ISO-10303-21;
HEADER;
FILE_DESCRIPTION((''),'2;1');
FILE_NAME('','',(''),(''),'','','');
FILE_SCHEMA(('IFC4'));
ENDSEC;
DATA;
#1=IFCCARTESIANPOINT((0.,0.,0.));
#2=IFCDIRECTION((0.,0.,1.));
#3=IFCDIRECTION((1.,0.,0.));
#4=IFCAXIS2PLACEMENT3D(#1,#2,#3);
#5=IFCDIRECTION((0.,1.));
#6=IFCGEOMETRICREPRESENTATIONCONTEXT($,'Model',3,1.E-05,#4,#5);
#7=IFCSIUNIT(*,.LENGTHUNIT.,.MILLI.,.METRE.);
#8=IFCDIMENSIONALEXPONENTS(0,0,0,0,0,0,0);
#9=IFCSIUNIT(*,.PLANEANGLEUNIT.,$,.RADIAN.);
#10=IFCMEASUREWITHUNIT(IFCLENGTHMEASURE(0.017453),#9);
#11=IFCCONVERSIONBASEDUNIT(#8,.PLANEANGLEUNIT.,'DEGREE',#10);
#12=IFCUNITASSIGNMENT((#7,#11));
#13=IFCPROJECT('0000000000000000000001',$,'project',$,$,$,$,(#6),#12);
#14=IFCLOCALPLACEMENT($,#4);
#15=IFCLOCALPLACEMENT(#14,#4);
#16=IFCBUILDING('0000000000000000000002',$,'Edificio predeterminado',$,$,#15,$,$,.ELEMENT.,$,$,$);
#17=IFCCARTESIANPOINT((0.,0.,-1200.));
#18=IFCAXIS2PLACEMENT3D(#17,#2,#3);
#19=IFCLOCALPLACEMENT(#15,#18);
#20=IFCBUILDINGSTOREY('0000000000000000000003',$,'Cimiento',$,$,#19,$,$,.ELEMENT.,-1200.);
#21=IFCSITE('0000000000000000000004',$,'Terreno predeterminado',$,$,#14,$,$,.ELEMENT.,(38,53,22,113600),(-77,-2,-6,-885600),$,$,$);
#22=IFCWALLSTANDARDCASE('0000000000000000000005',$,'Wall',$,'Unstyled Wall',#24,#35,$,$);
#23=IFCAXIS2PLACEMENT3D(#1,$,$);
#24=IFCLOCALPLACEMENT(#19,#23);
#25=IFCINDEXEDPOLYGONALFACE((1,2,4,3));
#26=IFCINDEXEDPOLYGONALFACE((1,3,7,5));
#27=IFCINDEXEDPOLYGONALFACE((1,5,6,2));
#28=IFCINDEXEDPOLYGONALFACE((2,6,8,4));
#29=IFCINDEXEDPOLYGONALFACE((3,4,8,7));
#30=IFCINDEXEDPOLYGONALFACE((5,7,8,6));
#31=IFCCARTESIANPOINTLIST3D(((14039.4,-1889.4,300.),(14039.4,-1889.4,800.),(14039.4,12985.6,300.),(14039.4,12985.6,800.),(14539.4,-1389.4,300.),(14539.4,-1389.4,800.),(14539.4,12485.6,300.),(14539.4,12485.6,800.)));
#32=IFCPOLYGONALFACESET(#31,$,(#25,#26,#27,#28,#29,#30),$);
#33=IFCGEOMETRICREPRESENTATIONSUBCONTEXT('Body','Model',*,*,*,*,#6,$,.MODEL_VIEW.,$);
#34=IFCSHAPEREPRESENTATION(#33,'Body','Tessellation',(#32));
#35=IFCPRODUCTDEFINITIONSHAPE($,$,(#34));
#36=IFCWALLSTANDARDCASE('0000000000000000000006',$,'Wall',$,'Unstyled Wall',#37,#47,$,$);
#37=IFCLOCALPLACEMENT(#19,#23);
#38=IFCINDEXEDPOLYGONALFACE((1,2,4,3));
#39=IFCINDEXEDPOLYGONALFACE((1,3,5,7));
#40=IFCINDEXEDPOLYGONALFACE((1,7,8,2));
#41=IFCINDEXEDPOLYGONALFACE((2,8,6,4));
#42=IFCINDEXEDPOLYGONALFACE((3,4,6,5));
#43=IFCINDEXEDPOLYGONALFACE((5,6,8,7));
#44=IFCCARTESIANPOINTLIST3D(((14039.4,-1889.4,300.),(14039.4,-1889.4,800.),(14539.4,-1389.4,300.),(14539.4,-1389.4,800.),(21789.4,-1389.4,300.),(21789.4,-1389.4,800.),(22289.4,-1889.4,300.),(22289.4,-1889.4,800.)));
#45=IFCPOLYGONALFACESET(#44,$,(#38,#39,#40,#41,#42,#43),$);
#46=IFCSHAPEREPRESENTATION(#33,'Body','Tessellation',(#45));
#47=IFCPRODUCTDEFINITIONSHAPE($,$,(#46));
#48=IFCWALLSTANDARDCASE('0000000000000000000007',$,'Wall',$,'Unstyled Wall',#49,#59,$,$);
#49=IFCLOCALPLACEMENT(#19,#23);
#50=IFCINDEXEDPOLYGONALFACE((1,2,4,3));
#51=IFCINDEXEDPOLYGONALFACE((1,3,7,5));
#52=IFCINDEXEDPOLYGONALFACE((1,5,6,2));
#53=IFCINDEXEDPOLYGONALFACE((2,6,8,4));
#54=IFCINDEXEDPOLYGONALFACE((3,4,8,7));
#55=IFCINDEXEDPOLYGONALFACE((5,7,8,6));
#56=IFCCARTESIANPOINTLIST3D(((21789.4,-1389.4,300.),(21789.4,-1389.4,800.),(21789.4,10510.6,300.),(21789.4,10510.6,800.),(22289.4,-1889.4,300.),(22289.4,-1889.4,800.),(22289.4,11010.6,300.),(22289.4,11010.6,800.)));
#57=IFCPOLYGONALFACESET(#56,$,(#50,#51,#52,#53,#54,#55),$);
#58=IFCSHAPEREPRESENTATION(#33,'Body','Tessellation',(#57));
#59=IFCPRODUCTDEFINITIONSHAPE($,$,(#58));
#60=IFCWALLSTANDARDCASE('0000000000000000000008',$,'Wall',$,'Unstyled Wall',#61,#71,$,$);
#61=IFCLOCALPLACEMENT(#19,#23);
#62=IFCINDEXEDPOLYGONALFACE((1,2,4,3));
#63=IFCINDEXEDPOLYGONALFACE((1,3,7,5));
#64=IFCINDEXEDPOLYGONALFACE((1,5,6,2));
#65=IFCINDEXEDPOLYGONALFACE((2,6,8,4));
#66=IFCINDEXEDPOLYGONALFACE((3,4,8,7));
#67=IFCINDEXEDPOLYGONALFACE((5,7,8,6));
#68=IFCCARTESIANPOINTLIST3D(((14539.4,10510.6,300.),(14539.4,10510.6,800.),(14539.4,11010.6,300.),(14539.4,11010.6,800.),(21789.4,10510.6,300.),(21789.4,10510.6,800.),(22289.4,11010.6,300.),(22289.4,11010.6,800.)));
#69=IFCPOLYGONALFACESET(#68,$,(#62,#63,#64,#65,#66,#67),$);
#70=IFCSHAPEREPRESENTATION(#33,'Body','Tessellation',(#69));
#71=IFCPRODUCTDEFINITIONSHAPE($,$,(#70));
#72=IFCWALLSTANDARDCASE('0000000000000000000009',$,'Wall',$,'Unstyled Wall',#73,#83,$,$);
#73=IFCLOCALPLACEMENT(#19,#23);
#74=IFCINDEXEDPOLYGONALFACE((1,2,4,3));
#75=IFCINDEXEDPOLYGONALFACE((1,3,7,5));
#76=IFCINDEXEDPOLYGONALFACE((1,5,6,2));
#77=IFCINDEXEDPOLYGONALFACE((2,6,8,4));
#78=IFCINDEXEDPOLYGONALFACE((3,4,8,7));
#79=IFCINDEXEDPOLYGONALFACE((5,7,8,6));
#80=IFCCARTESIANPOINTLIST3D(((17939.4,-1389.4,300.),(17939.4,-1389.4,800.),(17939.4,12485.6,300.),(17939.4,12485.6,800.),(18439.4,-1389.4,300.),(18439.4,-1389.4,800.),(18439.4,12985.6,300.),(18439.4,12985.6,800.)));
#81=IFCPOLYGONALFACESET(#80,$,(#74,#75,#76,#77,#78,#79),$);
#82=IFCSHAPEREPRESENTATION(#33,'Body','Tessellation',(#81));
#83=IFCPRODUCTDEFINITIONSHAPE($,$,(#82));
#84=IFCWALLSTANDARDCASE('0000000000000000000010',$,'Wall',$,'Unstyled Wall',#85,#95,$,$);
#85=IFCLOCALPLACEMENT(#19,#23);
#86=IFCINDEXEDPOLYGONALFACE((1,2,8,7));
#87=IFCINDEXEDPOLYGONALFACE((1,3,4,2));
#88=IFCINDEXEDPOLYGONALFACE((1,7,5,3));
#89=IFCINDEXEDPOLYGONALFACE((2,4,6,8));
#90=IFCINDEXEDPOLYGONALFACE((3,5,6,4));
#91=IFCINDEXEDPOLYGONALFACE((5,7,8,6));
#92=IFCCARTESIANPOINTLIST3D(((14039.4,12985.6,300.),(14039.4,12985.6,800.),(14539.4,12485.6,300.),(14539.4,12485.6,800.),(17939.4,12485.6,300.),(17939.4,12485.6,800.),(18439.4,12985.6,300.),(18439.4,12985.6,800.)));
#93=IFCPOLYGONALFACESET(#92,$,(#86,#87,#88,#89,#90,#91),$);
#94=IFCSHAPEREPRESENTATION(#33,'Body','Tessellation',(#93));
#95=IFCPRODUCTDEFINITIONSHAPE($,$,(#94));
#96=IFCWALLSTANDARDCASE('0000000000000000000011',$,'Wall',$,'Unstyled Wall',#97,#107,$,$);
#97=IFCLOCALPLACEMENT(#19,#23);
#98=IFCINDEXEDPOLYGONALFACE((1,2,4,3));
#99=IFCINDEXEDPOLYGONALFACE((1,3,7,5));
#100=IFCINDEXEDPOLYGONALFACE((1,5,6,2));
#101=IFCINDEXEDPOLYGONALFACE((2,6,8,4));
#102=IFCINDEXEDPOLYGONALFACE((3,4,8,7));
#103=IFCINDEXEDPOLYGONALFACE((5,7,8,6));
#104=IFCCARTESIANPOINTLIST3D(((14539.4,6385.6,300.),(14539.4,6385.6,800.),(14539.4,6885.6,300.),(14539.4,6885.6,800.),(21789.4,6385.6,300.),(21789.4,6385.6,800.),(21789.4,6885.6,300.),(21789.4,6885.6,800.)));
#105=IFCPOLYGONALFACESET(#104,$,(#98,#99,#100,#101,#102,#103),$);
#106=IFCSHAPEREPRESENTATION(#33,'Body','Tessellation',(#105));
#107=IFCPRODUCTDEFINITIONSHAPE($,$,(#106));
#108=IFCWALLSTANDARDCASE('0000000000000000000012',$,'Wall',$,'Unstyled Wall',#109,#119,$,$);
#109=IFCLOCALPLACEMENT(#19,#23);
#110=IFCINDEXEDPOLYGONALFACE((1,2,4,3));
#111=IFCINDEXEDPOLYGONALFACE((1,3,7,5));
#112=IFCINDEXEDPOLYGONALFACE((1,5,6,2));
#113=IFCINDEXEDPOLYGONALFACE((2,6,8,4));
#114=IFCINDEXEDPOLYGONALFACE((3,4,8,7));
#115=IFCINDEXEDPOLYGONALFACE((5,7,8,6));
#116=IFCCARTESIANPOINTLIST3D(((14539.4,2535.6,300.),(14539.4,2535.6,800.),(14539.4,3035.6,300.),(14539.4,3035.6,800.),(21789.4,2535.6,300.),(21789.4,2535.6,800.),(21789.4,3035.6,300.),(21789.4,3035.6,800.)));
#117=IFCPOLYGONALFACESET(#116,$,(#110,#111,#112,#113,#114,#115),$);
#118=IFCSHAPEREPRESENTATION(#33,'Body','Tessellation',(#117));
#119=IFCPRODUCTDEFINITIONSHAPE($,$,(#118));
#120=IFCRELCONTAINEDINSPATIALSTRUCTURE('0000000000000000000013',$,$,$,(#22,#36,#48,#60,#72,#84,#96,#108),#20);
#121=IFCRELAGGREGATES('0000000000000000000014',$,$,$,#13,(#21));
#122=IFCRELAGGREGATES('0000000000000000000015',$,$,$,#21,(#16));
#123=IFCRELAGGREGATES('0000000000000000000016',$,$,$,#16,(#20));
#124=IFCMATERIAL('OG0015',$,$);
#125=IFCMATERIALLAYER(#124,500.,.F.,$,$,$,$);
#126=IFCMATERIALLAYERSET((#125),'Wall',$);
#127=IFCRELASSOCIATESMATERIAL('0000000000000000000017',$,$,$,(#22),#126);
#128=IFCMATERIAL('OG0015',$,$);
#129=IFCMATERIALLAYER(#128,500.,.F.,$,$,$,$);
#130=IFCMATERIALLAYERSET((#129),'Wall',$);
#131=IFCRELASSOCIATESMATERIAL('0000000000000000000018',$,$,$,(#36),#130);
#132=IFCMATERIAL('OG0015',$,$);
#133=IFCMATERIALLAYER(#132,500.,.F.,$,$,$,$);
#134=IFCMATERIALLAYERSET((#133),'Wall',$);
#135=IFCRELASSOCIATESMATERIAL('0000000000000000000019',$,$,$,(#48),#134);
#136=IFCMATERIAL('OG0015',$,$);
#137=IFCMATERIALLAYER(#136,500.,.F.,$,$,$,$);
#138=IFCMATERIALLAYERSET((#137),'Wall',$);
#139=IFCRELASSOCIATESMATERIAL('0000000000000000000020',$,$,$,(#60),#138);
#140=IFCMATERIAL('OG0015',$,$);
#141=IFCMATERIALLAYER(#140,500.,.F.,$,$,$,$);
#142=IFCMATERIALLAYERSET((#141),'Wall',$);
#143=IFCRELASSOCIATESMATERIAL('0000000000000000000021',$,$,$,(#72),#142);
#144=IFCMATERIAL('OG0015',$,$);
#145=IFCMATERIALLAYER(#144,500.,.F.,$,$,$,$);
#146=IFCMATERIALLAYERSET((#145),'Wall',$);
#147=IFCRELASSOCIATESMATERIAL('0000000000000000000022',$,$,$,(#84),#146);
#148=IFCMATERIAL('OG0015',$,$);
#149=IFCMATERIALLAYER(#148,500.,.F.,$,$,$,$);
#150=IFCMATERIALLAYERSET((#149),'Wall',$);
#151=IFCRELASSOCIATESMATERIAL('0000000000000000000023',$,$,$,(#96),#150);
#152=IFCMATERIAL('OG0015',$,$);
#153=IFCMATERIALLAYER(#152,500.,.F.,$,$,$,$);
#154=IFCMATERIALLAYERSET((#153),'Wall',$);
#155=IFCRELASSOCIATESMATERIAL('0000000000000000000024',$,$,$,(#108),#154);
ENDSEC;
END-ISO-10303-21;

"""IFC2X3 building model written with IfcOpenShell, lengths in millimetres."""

from ifc_helpers import new_model, entity, si_unit, converted_unit, direction, frame, origin_with_axes, place, context, subcontext, project, spatial, polyline, outline, extrude, material, layer, layer_set, layer_usage, element, save


model = new_model("IFC2X3")

# Units and contexts
model_context = context("Model", 3, precision=1e-05, world=origin_with_axes(), true_north=direction((0.0, 1.0)))
body_context = subcontext(model_context, "Body", "Model", "MODEL_VIEW")
ifc_project = project(units=[si_unit("LENGTHUNIT", "METRE", prefix="MILLI"), converted_unit("PLANEANGLEUNIT", "DEGREE", entity("IfcLengthMeasure", 0.017453), si_unit("PLANEANGLEUNIT", "RADIAN"), dimensions=[0, 0, 0, 0, 0, 0, 0])], contexts=[model_context])

# Site, building, storey
site_placement = place(None, origin_with_axes())
site = spatial("IfcSite", under=ifc_project, at=site_placement, Name="Terreno predeterminado", CompositionType="ELEMENT", RefLatitude=(38, 53, 22, 113600), RefLongitude=(-77, -2, -6, -885600))
building_placement = place(site_placement, origin_with_axes())
building = spatial("IfcBuilding", under=site, at=building_placement, Name="Edificio predeterminado", CompositionType="ELEMENT")
storey_placement = place(building_placement, frame((0.0, 0.0, -1200.0), z_axis=(0.0, 0.0, 1.0), x_axis=(1.0, 0.0, 0.0)))
storey = spatial("IfcBuildingStorey", under=building, at=storey_placement, Name="Cimiento", CompositionType="ELEMENT", Elevation=-1200.0)

# Walls
ifc_material_1 = material(Name="OG0015")
ifc_layer_1 = layer(ifc_material_1, 500.0, ventilated=False)
ifc_layer_set_1 = layer_set([ifc_layer_1], Name="Wall")
ifc_layer_usage_1 = layer_usage(ifc_layer_set_1, "AXIS2", "POSITIVE", -250.0)
wall_1_placement = place(storey_placement, frame((14289.4, 12735.6, 300.0), z_axis=(0.0, 0.0, 1.0), x_axis=(0.0, -1.0, 0.0)))
element("IfcWallStandardCase", 1, at=wall_1_placement, inside=storey, material=ifc_layer_usage_1, Name="Wall", ObjectType="Unstyled Wall", context=body_context, shape_type="SweptSolid", body=[
    extrude(outline(polyline([(250.0, 250.0), (-250.0, -250.0), (14625.0, -250.0), (14125.0, 250.0), (250.0, 250.0)])), origin_with_axes(), (0.0, 0.0, 1.0), 500.0),
])
ifc_material_2 = material(Name="OG0015")
ifc_layer_2 = layer(ifc_material_2, 500.0, ventilated=False)
ifc_layer_set_2 = layer_set([ifc_layer_2], Name="Wall")
ifc_layer_usage_2 = layer_usage(ifc_layer_set_2, "AXIS2", "POSITIVE", -250.0)
wall_2_placement = place(storey_placement, frame((14289.4, -1639.4, 300.0), z_axis=(0.0, 0.0, 1.0), x_axis=(1.0, 0.0, 0.0)))
element("IfcWallStandardCase", 2, at=wall_2_placement, inside=storey, material=ifc_layer_usage_2, Name="Wall", ObjectType="Unstyled Wall", context=body_context, shape_type="SweptSolid", body=[
    extrude(outline(polyline([(-250.0, -250.0), (250.0, 250.0), (7500.0, 250.0), (8000.0, -250.0), (-250.0, -250.0)])), origin_with_axes(), (0.0, 0.0, 1.0), 500.0),
])
ifc_material_3 = material(Name="OG0015")
ifc_layer_3 = layer(ifc_material_3, 500.0, ventilated=False)
ifc_layer_set_3 = layer_set([ifc_layer_3], Name="Wall")
ifc_layer_usage_3 = layer_usage(ifc_layer_set_3, "AXIS2", "POSITIVE", -250.0)
wall_3_placement = place(storey_placement, frame((22039.4, -1639.4, 300.0), z_axis=(0.0, 0.0, 1.0), x_axis=(0.0, 1.0, 0.0)))
element("IfcWallStandardCase", 3, at=wall_3_placement, inside=storey, material=ifc_layer_usage_3, Name="Wall", ObjectType="Unstyled Wall", context=body_context, shape_type="SweptSolid", body=[
    extrude(outline(polyline([(-250.0, -250.0), (250.0, 250.0), (12150.0, 250.0), (12650.0, -250.0), (-250.0, -250.0)])), origin_with_axes(), (0.0, 0.0, 1.0), 500.0),
])
ifc_material_4 = material(Name="OG0015")
ifc_layer_4 = layer(ifc_material_4, 500.0, ventilated=False)
ifc_layer_set_4 = layer_set([ifc_layer_4], Name="Wall")
ifc_layer_usage_4 = layer_usage(ifc_layer_set_4, "AXIS2", "POSITIVE", -250.0)
wall_4_placement = place(storey_placement, frame((22039.4, 10760.6, 300.0), z_axis=(0.0, 0.0, 1.0), x_axis=(-1.0, 0.0, 0.0)))
element("IfcWallStandardCase", 4, at=wall_4_placement, inside=storey, material=ifc_layer_usage_4, Name="Wall", ObjectType="Unstyled Wall", context=body_context, shape_type="SweptSolid", body=[
    extrude(outline(polyline([(-250.0, -250.0), (250.0, 250.0), (7500.0, 250.0), (7500.0, -250.0), (-250.0, -250.0)])), origin_with_axes(), (0.0, 0.0, 1.0), 500.0),
])
ifc_material_5 = material(Name="OG0015")
ifc_layer_5 = layer(ifc_material_5, 500.0, ventilated=False)
ifc_layer_set_5 = layer_set([ifc_layer_5], Name="Wall")
ifc_layer_usage_5 = layer_usage(ifc_layer_set_5, "AXIS2", "POSITIVE", -250.0)
wall_5_placement = place(storey_placement, frame((18189.4, -1639.4, 300.0), z_axis=(0.0, 0.0, 1.0), x_axis=(0.0, 1.0, 0.0)))
element("IfcWallStandardCase", 5, at=wall_5_placement, inside=storey, material=ifc_layer_usage_5, Name="Wall", ObjectType="Unstyled Wall", context=body_context, shape_type="SweptSolid", body=[
    extrude(outline(polyline([(250.0, 250.0), (250.0, -250.0), (14625.0, -250.0), (14125.0, 250.0), (250.0, 250.0)])), origin_with_axes(), (0.0, 0.0, 1.0), 500.0),
])
ifc_material_6 = material(Name="OG0015")
ifc_layer_6 = layer(ifc_material_6, 500.0, ventilated=False)
ifc_layer_set_6 = layer_set([ifc_layer_6], Name="Wall")
ifc_layer_usage_6 = layer_usage(ifc_layer_set_6, "AXIS2", "POSITIVE", -250.0)
wall_6_placement = place(storey_placement, frame((18189.4, 12735.6, 300.0), z_axis=(0.0, 0.0, 1.0), x_axis=(-1.0, 0.0, 0.0)))
element("IfcWallStandardCase", 6, at=wall_6_placement, inside=storey, material=ifc_layer_usage_6, Name="Wall", ObjectType="Unstyled Wall", context=body_context, shape_type="SweptSolid", body=[
    extrude(outline(polyline([(-250.0, -250.0), (250.0, 250.0), (3650.0, 250.0), (4150.0, -250.0), (-250.0, -250.0)])), origin_with_axes(), (0.0, 0.0, 1.0), 500.0),
])
ifc_material_7 = material(Name="OG0015")
ifc_layer_7 = layer(ifc_material_7, 500.0, ventilated=False)
ifc_layer_set_7 = layer_set([ifc_layer_7], Name="Wall")
ifc_layer_usage_7 = layer_usage(ifc_layer_set_7, "AXIS2", "POSITIVE", -250.0)
wall_7_placement = place(storey_placement, frame((14289.4, 6635.6, 300.0), z_axis=(0.0, 0.0, 1.0), x_axis=(1.0, 0.0, 0.0)))
element("IfcWallStandardCase", 7, at=wall_7_placement, inside=storey, material=ifc_layer_usage_7, Name="Wall", ObjectType="Unstyled Wall", context=body_context, shape_type="SweptSolid", body=[
    extrude(outline(polyline([(250.0, -250.0), (250.0, 250.0), (7500.0, 250.0), (7500.0, -250.0), (250.0, -250.0)])), origin_with_axes(), (0.0, 0.0, 1.0), 500.0),
])
ifc_material_8 = material(Name="OG0015")
ifc_layer_8 = layer(ifc_material_8, 500.0, ventilated=False)
ifc_layer_set_8 = layer_set([ifc_layer_8], Name="Wall")
ifc_layer_usage_8 = layer_usage(ifc_layer_set_8, "AXIS2", "POSITIVE", -250.0)
wall_8_placement = place(storey_placement, frame((14289.4, 2785.6, 300.0), z_axis=(0.0, 0.0, 1.0), x_axis=(1.0, 0.0, 0.0)))
element("IfcWallStandardCase", 8, at=wall_8_placement, inside=storey, material=ifc_layer_usage_8, Name="Wall", ObjectType="Unstyled Wall", context=body_context, shape_type="SweptSolid", body=[
    extrude(outline(polyline([(250.0, -250.0), (250.0, 250.0), (7500.0, 250.0), (7500.0, -250.0), (250.0, -250.0)])), origin_with_axes(), (0.0, 0.0, 1.0), 500.0),
])

save(model, "model.ifc")
